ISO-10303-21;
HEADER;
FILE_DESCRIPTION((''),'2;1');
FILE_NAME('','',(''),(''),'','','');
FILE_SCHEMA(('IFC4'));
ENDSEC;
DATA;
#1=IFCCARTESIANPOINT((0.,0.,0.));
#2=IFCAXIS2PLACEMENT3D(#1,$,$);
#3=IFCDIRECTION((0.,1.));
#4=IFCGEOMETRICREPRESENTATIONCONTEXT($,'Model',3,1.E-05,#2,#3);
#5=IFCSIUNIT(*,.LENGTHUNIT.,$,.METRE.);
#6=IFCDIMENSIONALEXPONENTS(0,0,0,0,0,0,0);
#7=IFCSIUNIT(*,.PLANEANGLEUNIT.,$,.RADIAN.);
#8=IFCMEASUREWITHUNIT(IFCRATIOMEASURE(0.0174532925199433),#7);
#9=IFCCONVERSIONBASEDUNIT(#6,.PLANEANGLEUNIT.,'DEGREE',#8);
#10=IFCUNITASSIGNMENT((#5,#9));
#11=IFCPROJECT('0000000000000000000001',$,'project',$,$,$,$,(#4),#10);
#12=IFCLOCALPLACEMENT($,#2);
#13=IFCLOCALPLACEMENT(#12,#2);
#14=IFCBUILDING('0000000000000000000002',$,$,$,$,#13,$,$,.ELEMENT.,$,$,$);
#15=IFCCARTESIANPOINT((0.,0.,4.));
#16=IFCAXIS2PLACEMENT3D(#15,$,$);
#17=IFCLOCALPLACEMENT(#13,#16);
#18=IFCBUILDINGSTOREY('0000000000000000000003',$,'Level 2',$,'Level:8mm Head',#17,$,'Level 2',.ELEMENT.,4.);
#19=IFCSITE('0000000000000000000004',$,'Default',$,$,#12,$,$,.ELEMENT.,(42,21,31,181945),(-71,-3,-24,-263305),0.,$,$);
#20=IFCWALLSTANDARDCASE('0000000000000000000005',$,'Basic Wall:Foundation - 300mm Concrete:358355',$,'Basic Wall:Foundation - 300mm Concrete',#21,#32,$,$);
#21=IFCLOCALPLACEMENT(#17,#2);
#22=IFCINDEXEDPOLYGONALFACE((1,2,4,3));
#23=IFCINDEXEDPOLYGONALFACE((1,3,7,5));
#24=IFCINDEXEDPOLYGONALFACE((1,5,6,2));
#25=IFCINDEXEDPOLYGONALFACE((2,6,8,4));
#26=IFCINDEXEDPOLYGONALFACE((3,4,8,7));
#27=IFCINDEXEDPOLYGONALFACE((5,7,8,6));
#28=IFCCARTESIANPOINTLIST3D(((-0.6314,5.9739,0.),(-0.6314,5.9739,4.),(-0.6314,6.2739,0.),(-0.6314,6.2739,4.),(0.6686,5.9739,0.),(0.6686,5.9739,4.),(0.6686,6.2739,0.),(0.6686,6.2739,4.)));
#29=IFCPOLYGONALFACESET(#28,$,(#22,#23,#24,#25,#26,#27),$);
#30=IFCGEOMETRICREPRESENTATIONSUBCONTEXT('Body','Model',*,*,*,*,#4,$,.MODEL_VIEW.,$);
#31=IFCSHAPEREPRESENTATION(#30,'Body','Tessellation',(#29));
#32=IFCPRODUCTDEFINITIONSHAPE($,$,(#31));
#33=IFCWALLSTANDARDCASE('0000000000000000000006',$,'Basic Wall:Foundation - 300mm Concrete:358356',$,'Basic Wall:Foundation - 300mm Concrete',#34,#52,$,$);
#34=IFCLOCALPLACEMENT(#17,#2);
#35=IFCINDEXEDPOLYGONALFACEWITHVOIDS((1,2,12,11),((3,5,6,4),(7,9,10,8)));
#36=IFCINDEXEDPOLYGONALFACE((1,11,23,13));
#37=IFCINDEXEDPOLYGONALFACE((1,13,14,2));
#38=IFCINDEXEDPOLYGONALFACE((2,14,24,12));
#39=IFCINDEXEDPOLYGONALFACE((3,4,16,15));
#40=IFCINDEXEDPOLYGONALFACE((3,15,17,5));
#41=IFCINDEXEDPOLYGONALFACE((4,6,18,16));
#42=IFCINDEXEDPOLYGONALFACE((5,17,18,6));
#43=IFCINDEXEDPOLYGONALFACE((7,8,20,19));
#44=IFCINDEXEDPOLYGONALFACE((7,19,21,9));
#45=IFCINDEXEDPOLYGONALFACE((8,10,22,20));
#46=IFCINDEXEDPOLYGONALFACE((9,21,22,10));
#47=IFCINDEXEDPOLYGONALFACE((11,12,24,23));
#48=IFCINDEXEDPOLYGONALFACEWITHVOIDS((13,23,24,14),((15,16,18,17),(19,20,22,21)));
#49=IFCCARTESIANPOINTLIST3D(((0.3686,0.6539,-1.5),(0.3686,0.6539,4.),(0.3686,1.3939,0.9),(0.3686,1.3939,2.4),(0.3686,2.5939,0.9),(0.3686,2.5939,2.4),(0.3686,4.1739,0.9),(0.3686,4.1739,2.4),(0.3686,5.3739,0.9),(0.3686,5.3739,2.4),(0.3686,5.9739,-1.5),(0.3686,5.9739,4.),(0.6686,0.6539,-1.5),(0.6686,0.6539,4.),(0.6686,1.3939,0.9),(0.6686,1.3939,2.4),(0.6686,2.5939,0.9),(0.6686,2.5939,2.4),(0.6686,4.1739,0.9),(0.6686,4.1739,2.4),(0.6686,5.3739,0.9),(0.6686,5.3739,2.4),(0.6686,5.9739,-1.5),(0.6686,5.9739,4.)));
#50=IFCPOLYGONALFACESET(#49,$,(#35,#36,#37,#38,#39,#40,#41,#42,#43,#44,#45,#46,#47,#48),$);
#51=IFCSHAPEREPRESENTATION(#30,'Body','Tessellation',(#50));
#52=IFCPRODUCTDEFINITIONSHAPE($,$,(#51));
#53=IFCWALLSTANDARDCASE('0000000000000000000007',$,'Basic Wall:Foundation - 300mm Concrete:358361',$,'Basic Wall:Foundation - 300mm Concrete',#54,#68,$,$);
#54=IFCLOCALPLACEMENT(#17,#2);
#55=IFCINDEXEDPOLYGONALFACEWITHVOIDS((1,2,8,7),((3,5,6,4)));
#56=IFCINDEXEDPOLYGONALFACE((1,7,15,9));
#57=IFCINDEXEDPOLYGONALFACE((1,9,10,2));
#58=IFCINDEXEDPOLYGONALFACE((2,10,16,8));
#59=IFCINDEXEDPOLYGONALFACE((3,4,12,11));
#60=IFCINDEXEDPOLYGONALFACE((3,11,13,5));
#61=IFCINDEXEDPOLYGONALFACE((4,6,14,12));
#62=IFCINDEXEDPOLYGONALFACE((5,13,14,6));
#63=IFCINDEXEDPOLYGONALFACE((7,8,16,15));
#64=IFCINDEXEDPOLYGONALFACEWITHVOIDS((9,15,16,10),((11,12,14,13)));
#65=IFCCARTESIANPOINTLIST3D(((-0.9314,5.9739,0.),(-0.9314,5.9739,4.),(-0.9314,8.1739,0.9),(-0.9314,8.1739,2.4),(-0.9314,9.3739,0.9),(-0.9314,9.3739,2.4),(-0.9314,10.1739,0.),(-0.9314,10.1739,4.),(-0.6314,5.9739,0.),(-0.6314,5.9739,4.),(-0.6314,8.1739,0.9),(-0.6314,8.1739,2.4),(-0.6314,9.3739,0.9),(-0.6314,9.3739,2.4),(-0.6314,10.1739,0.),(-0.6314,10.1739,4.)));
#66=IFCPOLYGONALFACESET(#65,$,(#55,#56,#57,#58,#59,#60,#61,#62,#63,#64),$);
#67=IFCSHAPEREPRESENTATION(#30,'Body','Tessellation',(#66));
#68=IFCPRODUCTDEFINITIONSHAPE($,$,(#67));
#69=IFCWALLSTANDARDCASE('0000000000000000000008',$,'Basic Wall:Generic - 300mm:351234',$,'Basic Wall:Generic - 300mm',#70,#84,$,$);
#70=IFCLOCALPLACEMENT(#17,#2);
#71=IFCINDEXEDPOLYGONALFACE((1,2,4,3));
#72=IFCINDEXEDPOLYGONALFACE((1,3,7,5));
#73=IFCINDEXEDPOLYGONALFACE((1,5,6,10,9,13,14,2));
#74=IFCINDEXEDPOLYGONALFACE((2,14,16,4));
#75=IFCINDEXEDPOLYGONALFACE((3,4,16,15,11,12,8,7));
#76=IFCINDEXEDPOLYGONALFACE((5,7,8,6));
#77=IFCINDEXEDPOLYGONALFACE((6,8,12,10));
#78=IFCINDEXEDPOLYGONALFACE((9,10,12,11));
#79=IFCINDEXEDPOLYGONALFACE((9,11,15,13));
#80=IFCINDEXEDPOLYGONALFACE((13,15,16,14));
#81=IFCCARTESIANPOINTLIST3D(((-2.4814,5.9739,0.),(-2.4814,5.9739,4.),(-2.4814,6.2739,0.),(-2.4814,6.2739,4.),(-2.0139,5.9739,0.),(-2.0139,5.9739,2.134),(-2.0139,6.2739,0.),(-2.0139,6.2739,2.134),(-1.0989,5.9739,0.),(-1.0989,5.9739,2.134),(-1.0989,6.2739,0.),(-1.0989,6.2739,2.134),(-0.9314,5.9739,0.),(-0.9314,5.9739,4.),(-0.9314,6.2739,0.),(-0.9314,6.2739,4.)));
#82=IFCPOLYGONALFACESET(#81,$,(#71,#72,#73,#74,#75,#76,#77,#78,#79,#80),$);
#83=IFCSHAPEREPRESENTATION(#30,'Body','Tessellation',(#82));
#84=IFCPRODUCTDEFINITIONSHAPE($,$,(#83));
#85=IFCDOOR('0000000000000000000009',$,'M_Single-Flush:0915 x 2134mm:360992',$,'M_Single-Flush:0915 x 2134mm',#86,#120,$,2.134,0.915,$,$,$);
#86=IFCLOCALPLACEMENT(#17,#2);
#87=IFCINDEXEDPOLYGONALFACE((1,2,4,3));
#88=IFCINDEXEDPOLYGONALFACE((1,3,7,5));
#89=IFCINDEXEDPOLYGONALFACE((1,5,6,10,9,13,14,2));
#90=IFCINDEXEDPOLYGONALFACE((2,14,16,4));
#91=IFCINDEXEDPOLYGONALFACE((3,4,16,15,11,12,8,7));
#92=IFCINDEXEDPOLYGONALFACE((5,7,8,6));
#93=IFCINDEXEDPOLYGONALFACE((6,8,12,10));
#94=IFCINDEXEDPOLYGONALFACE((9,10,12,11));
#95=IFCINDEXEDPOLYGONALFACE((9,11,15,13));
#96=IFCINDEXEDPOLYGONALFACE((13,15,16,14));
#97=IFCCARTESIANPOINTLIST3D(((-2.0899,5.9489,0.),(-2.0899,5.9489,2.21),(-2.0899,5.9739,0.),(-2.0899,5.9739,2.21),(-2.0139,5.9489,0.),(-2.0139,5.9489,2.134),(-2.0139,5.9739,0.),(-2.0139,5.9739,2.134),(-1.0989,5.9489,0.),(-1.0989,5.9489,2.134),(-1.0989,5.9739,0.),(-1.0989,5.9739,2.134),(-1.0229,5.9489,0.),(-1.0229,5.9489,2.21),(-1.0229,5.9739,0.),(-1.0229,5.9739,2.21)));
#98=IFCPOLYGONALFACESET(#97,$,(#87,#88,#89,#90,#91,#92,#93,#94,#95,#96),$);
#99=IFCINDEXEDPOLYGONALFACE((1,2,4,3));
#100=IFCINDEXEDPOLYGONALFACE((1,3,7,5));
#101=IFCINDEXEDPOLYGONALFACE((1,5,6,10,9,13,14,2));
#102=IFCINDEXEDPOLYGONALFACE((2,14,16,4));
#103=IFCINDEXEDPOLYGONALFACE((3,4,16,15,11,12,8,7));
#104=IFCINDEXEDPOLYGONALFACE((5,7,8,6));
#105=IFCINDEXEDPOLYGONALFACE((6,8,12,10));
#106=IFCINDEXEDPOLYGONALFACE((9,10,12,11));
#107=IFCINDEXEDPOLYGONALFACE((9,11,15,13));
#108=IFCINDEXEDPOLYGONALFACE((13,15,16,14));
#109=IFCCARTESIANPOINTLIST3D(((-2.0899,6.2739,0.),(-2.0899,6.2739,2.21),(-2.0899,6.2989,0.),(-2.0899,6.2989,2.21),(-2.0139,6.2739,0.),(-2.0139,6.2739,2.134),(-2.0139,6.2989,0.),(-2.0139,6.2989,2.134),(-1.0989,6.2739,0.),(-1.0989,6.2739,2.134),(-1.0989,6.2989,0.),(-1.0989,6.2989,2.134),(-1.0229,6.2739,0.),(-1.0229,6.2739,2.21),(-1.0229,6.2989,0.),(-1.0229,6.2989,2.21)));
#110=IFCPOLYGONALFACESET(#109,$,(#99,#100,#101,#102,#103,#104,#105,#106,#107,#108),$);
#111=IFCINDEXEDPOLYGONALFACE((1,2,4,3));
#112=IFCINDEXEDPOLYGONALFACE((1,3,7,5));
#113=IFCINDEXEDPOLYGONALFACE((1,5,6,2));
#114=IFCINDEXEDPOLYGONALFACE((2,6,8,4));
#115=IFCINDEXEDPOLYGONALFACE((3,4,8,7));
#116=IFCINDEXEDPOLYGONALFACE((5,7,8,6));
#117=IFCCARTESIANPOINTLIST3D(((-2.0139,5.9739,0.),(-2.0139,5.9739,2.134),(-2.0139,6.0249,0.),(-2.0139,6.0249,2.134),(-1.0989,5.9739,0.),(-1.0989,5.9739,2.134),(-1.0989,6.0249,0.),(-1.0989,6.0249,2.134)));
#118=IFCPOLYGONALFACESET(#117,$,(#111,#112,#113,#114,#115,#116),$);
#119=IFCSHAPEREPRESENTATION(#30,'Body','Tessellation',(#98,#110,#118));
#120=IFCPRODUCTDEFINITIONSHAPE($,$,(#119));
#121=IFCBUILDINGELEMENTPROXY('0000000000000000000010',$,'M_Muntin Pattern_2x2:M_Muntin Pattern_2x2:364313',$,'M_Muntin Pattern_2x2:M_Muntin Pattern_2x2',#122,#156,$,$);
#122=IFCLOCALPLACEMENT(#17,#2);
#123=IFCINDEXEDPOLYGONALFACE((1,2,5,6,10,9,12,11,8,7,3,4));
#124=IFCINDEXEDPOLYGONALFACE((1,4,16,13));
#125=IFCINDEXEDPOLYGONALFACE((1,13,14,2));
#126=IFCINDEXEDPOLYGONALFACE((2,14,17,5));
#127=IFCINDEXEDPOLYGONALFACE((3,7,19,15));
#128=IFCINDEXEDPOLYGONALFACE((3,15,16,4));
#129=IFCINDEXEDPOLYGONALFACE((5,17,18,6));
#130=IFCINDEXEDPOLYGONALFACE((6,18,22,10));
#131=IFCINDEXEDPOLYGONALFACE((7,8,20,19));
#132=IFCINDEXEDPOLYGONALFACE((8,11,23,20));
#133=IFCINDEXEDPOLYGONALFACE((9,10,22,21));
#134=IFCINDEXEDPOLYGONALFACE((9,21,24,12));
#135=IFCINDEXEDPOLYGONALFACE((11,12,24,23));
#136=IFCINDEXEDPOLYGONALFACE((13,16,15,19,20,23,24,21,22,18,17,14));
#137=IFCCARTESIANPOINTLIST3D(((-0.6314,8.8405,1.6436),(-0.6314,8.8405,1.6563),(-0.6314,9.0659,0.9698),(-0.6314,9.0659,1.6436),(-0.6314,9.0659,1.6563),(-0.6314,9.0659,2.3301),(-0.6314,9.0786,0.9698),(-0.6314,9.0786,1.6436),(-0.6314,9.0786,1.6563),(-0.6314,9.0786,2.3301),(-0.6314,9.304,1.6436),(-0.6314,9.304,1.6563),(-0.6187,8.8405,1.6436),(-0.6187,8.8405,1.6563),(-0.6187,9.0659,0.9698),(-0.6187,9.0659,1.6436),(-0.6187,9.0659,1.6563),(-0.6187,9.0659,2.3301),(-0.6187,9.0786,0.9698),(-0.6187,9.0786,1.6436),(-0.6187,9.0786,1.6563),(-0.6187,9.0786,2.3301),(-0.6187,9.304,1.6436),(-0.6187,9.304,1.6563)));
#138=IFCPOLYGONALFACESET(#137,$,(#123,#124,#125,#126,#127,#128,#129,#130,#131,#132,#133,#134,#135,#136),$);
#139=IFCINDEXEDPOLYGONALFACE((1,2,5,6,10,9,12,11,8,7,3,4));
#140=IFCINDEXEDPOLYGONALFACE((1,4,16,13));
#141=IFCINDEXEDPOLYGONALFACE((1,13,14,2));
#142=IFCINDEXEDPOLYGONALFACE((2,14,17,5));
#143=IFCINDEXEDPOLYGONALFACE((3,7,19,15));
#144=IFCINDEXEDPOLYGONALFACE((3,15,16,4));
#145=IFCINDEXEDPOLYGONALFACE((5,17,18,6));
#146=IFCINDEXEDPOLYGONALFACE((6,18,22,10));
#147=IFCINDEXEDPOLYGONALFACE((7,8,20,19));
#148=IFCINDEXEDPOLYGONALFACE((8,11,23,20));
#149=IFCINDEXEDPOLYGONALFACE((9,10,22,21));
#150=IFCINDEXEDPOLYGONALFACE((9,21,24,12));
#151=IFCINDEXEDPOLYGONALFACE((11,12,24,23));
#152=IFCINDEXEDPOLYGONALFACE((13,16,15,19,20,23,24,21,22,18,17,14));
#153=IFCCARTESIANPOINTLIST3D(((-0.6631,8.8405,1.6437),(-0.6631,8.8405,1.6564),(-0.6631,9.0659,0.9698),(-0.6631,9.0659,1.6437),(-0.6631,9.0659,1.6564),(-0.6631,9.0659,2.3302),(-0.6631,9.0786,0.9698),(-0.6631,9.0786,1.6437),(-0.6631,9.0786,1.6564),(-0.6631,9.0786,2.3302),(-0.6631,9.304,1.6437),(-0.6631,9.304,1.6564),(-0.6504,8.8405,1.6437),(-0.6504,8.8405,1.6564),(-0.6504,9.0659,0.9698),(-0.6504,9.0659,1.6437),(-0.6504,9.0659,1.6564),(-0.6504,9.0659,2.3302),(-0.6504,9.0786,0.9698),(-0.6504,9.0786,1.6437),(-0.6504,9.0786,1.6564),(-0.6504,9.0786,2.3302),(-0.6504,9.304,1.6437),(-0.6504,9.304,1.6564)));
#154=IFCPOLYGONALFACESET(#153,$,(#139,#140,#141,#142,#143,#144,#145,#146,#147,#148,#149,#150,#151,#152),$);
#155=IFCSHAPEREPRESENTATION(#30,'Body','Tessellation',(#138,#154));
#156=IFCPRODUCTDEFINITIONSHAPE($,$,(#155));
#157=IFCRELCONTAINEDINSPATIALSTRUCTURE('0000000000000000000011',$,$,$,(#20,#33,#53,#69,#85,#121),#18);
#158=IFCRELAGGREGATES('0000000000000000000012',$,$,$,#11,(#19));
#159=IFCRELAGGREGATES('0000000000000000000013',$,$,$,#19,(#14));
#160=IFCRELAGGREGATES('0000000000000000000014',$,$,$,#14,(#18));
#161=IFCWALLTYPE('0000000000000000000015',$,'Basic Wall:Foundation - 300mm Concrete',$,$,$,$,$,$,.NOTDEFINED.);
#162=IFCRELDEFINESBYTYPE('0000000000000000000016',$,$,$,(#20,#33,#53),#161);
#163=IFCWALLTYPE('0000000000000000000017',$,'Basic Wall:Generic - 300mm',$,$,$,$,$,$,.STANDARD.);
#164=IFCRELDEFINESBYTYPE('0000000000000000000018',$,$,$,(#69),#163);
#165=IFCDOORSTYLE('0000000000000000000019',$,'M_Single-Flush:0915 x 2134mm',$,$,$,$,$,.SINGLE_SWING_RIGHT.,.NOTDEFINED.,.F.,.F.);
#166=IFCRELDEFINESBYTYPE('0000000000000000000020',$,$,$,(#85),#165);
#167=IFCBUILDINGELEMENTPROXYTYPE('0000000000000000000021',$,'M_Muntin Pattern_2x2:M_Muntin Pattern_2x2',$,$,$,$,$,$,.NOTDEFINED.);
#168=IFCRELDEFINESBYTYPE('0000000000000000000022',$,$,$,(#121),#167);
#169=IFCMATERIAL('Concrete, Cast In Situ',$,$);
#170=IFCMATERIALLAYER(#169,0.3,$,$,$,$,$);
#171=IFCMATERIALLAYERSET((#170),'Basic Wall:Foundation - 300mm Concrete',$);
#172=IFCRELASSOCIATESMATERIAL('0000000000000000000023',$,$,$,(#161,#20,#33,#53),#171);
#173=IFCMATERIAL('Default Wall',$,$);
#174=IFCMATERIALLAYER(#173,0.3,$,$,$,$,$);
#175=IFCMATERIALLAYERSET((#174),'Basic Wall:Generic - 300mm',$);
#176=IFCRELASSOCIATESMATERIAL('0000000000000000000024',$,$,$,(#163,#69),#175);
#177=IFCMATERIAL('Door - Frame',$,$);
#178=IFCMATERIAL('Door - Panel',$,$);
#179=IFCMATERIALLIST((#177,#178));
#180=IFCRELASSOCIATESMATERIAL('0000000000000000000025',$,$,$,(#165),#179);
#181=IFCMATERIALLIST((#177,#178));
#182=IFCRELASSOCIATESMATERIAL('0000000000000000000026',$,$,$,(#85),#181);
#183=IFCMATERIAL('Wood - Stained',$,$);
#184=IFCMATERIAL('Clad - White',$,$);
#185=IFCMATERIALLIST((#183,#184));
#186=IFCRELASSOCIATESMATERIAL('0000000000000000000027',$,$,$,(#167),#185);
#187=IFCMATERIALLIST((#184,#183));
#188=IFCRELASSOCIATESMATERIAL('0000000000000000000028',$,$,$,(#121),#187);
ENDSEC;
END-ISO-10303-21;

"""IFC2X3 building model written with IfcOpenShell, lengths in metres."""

from ifc_helpers import new_model, entity, si_unit, converted_unit, direction, frame, frame_2d, origin, place, context, subcontext, project, spatial, polyline, rectangle, outline, extrude, source, transform, mapped, material, material_list, layer, layer_set, layer_usage, type_object, type_shapes, element, fill, save


model = new_model("IFC2X3")

# Units and contexts
model_context = context("Model", 3, precision=1e-05, world=origin(), true_north=direction((0.0, 1.0)))
body_context = subcontext(model_context, "Body", "Model", "MODEL_VIEW")
ifc_project = project(units=[si_unit("LENGTHUNIT", "METRE"), converted_unit("PLANEANGLEUNIT", "DEGREE", entity("IfcRatioMeasure", 0.0174532925199433), si_unit("PLANEANGLEUNIT", "RADIAN"), dimensions=[0, 0, 0, 0, 0, 0, 0])], contexts=[model_context])

# Site, building, storey
site_placement = place(None, origin())
site = spatial("IfcSite", under=ifc_project, at=site_placement, Name="Default", CompositionType="ELEMENT", RefLatitude=(42, 21, 31, 181945), RefLongitude=(-71, -3, -24, -263305), RefElevation=0.0)
building_placement = place(site_placement, origin())
building = spatial("IfcBuilding", under=site, at=building_placement, CompositionType="ELEMENT")
storey_placement = place(building_placement, frame((0.0, 0.0, 4.0)))
storey = spatial("IfcBuildingStorey", under=building, at=storey_placement, Name="Level 2", ObjectType="Level:8mm Head", LongName="Level 2", CompositionType="ELEMENT", Elevation=4.0)

# Wall
ifc_material_1 = material(Name="Concrete, Cast In Situ")
ifc_layer_1 = layer(ifc_material_1, 0.3)
ifc_layer_set_1 = layer_set([ifc_layer_1], Name="Basic Wall:Foundation - 300mm Concrete")
ifc_layer_usage_1 = layer_usage(ifc_layer_set_1, "AXIS2", "NEGATIVE", 0.15)
wall_type_1 = type_object("IfcWallType", Name="Basic Wall:Foundation - 300mm Concrete", PredefinedType="NOTDEFINED", material=ifc_layer_set_1)
wall_1_placement = place(storey_placement, frame((-0.6314, 6.1239, 0.0)))
element("IfcWallStandardCase", 1, at=wall_1_placement, inside=storey, type_object=wall_type_1, material=ifc_layer_usage_1, Name="Basic Wall:Foundation - 300mm Concrete:358355", ObjectType="Basic Wall:Foundation - 300mm Concrete", context=body_context, shape_type="SweptSolid", body=[
    extrude(rectangle(XDim=1.3, YDim=0.3, at=frame_2d((0.65, 0.0), x_axis=(-1.0, 0.0))), origin(), (0.0, 0.0, 1.0), 4.0),
])

# Wall, openings
ifc_layer_usage_2 = layer_usage(ifc_layer_set_1, "AXIS2", "NEGATIVE", 0.15)
wall_2_placement = place(storey_placement, frame((0.5186, 5.9739, -1.5), z_axis=(0.0, 0.0, 1.0), x_axis=(0.0, -1.0, 0.0)))
wall_2 = element("IfcWallStandardCase", 2, at=wall_2_placement, inside=storey, type_object=wall_type_1, material=ifc_layer_usage_2, Name="Basic Wall:Foundation - 300mm Concrete:358356", ObjectType="Basic Wall:Foundation - 300mm Concrete", context=body_context, shape_type="SweptSolid", body=[
    extrude(rectangle(XDim=5.32, YDim=0.3, at=frame_2d((2.66, 0.0), x_axis=(-1.0, 0.0))), origin(), (0.0, 0.0, 1.0), 5.5),
])
opening_1_placement = place(wall_2_placement, frame((0.6, -0.15, 2.4)))
element("IfcOpeningElement", 3, at=opening_1_placement, cuts=wall_2, ObjectType="Opening", context=body_context, shape_type="SweptSolid", body=[
    extrude(rectangle(XDim=1.5, YDim=1.2, at=frame_2d((0.75, 0.6), x_axis=(-1.0, 0.0))), frame((0.0, 0.0, 0.0), z_axis=(0.0, 1.0, 0.0), x_axis=(0.0, 0.0, 1.0)), (0.0, 0.0, 1.0), 0.3),
])
opening_2_placement = place(wall_2_placement, frame((3.38, -0.15, 2.4)))
element("IfcOpeningElement", 4, at=opening_2_placement, cuts=wall_2, ObjectType="Opening", context=body_context, shape_type="SweptSolid", body=[
    extrude(rectangle(XDim=1.5, YDim=1.2, at=frame_2d((0.75, 0.6), x_axis=(-1.0, 0.0))), frame((0.0, 0.0, 0.0), z_axis=(0.0, 1.0, 0.0), x_axis=(0.0, 0.0, 1.0)), (0.0, 0.0, 1.0), 0.3),
])

# Wall, opening
ifc_layer_usage_3 = layer_usage(ifc_layer_set_1, "AXIS2", "NEGATIVE", 0.15)
wall_3_placement = place(storey_placement, frame((-0.7814, 10.1739, 0.0), z_axis=(0.0, 0.0, 1.0), x_axis=(0.0, -1.0, 0.0)))
wall_3 = element("IfcWallStandardCase", 5, at=wall_3_placement, inside=storey, type_object=wall_type_1, material=ifc_layer_usage_3, Name="Basic Wall:Foundation - 300mm Concrete:358361", ObjectType="Basic Wall:Foundation - 300mm Concrete", context=body_context, shape_type="SweptSolid", body=[
    extrude(rectangle(XDim=4.2, YDim=0.3, at=frame_2d((2.1, 0.0), x_axis=(-1.0, 0.0))), origin(), (0.0, 0.0, 1.0), 4.0),
])
opening_3_placement = place(wall_3_placement, frame((0.8, -0.15, 0.9)))
element("IfcOpeningElement", 6, at=opening_3_placement, cuts=wall_3, ObjectType="Opening", context=body_context, shape_type="SweptSolid", body=[
    extrude(rectangle(XDim=1.5, YDim=1.2, at=frame_2d((0.75, 0.6), x_axis=(-1.0, 0.0))), frame((0.0, 0.0, 0.0), z_axis=(0.0, 1.0, 0.0), x_axis=(0.0, 0.0, 1.0)), (0.0, 0.0, 1.0), 0.3),
])

# Wall, opening, door
ifc_material_2 = material(Name="Default Wall")
ifc_layer_2 = layer(ifc_material_2, 0.3)
ifc_layer_set_2 = layer_set([ifc_layer_2], Name="Basic Wall:Generic - 300mm")
ifc_layer_usage_4 = layer_usage(ifc_layer_set_2, "AXIS2", "NEGATIVE", 0.15)
wall_type_2 = type_object("IfcWallType", Name="Basic Wall:Generic - 300mm", PredefinedType="STANDARD", material=ifc_layer_set_2)
wall_4_placement = place(storey_placement, frame((-0.9314, 6.1239, 0.0), z_axis=(0.0, 0.0, 1.0), x_axis=(-1.0, 0.0, 0.0)))
wall_4 = element("IfcWallStandardCase", 7, at=wall_4_placement, inside=storey, type_object=wall_type_2, material=ifc_layer_usage_4, Name="Basic Wall:Generic - 300mm:351234", ObjectType="Basic Wall:Generic - 300mm", context=body_context, shape_type="SweptSolid", body=[
    extrude(rectangle(XDim=1.55, YDim=0.3, at=frame_2d((0.775, 0.0), x_axis=(-1.0, 0.0))), origin(), (0.0, 0.0, 1.0), 4.0),
])
opening_4_placement = place(wall_4_placement, frame((0.1675, -0.15, 0.0)))
opening_4 = element("IfcOpeningElement", 8, at=opening_4_placement, cuts=wall_4, ObjectType="Opening", context=body_context, shape_type="SweptSolid", body=[
    extrude(rectangle(XDim=0.915, YDim=2.134, at=frame_2d((1.067, 0.4575), x_axis=(0.0, 1.0))), frame((0.0, 0.0, 0.0), z_axis=(0.0, 1.0, 0.0), x_axis=(0.0, 0.0, 1.0)), (0.0, 0.0, 1.0), 0.3),
])
ifc_material_3 = material(Name="Door - Frame")
ifc_material_4 = material(Name="Door - Panel")
ifc_material_list_1 = material_list([ifc_material_3, ifc_material_4])
ifc_material_list_2 = material_list([ifc_material_3, ifc_material_4])
door_style = type_object("IfcDoorStyle", Name="M_Single-Flush:0915 x 2134mm", ConstructionType="NOTDEFINED", OperationType="SINGLE_SWING_RIGHT", ParameterTakesPrecedence=False, Sizeable=False, material=ifc_material_list_2)
shared_shape_1 = source(origin(), body_context, "Body", "SweptSolid", [
    extrude(outline(polyline([(-0.5335, -1.124), (0.5335, -1.124), (0.5335, 1.086), (0.4575, 1.086), (0.4575, -1.048), (-0.4575, -1.048), (-0.4575, 1.086), (-0.5335, 1.086), (-0.5335, -1.124)])), frame((0.4575, 0.3, 1.086), z_axis=(0.0, 1.0, 0.0), x_axis=(1.0, 0.0, 0.0)), (0.0, 0.0, 1.0), 0.025),
    extrude(outline(polyline([(-1.124, -0.5335), (1.086, -0.5335), (1.086, -0.4575), (-1.048, -0.4575), (-1.048, 0.4575), (1.086, 0.4575), (1.086, 0.5335), (-1.124, 0.5335), (-1.124, -0.5335)])), frame((0.4575, -0.025, 1.086), z_axis=(0.0, 1.0, 0.0), x_axis=(0.0, 0.0, -1.0)), (0.0, 0.0, 1.0), 0.025),
    extrude(rectangle(XDim=0.051, YDim=0.915, at=frame_2d((0.0, 0.0), x_axis=(1.0, 0.0))), frame((0.4575, 0.2745, 0.0), z_axis=(0.0, 0.0, 1.0), x_axis=(0.0, 1.0, 0.0)), (0.0, 0.0, 1.0), 2.134),
])
type_shapes(door_style, [shared_shape_1])
door_placement = place(opening_4_placement, origin())
door = element("IfcDoor", 9, at=door_placement, inside=storey, type_object=door_style, material=ifc_material_list_1, Name="M_Single-Flush:0915 x 2134mm:360992", ObjectType="M_Single-Flush:0915 x 2134mm", OverallHeight=2.134, OverallWidth=0.915, context=body_context, shape_type="MappedRepresentation", body=[
    mapped(shared_shape_1, transform((0.0, 0.0, 0.0), scale=1.0)),
])
fill(opening_4, door)

# Building element proxy
ifc_material_5 = material(Name="Clad - White")
ifc_material_6 = material(Name="Wood - Stained")
ifc_material_list_3 = material_list([ifc_material_5, ifc_material_6])
ifc_material_list_4 = material_list([ifc_material_6, ifc_material_5])
building_element_proxy_type_1 = type_object("IfcBuildingElementProxyType", Name="M_Muntin Pattern_2x2:M_Muntin Pattern_2x2", PredefinedType="NOTDEFINED", material=ifc_material_list_4)
shared_shape_2 = source(origin(), body_context, "Body", "SweptSolid", [
    extrude(outline(polyline([(0.0064, -0.0064), (0.6801, -0.0064), (0.6801, 0.0063), (0.0064, 0.0063), (0.0064, 0.2317), (-0.0063, 0.2317), (-0.0063, 0.0063), (-0.6802, 0.0063), (-0.6802, -0.0064), (-0.0063, -0.0064), (-0.0063, -0.2317), (0.0064, -0.2317), (0.0064, -0.0064)])), frame((0.0, 0.0095, 0.6801), z_axis=(0.0, 1.0, 0.0), x_axis=(0.0, 0.0, 1.0)), (0.0, 0.0, 1.0), 0.0127),
    extrude(outline(polyline([(0.0064, -0.0064), (0.6802, -0.0064), (0.6802, 0.0063), (0.0064, 0.0063), (0.0064, 0.2317), (-0.0063, 0.2317), (-0.0063, 0.0063), (-0.6802, 0.0063), (-0.6802, -0.0064), (-0.0063, -0.0064), (-0.0063, -0.2317), (0.0064, -0.2317), (0.0064, -0.0064)])), frame((0.0, -0.0222, 0.6802), z_axis=(0.0, 1.0, 0.0), x_axis=(0.0, 0.0, 1.0)), (0.0, 0.0, 1.0), 0.0127),
])
type_shapes(building_element_proxy_type_1, [shared_shape_2])
proxy_1_placement = place(storey_placement, frame((-0.6409, 9.0723, 0.9698), z_axis=(0.0, 0.0, 1.0), x_axis=(0.0, -1.0, 0.0)))
element("IfcBuildingElementProxy", 10, at=proxy_1_placement, inside=storey, type_object=building_element_proxy_type_1, material=ifc_material_list_3, Name="M_Muntin Pattern_2x2:M_Muntin Pattern_2x2:364313", ObjectType="M_Muntin Pattern_2x2:M_Muntin Pattern_2x2", context=body_context, shape_type="MappedRepresentation", body=[
    mapped(shared_shape_2, transform((0.0, 0.0, 0.0), scale=1.0)),
])

save(model, "model.ifc")
